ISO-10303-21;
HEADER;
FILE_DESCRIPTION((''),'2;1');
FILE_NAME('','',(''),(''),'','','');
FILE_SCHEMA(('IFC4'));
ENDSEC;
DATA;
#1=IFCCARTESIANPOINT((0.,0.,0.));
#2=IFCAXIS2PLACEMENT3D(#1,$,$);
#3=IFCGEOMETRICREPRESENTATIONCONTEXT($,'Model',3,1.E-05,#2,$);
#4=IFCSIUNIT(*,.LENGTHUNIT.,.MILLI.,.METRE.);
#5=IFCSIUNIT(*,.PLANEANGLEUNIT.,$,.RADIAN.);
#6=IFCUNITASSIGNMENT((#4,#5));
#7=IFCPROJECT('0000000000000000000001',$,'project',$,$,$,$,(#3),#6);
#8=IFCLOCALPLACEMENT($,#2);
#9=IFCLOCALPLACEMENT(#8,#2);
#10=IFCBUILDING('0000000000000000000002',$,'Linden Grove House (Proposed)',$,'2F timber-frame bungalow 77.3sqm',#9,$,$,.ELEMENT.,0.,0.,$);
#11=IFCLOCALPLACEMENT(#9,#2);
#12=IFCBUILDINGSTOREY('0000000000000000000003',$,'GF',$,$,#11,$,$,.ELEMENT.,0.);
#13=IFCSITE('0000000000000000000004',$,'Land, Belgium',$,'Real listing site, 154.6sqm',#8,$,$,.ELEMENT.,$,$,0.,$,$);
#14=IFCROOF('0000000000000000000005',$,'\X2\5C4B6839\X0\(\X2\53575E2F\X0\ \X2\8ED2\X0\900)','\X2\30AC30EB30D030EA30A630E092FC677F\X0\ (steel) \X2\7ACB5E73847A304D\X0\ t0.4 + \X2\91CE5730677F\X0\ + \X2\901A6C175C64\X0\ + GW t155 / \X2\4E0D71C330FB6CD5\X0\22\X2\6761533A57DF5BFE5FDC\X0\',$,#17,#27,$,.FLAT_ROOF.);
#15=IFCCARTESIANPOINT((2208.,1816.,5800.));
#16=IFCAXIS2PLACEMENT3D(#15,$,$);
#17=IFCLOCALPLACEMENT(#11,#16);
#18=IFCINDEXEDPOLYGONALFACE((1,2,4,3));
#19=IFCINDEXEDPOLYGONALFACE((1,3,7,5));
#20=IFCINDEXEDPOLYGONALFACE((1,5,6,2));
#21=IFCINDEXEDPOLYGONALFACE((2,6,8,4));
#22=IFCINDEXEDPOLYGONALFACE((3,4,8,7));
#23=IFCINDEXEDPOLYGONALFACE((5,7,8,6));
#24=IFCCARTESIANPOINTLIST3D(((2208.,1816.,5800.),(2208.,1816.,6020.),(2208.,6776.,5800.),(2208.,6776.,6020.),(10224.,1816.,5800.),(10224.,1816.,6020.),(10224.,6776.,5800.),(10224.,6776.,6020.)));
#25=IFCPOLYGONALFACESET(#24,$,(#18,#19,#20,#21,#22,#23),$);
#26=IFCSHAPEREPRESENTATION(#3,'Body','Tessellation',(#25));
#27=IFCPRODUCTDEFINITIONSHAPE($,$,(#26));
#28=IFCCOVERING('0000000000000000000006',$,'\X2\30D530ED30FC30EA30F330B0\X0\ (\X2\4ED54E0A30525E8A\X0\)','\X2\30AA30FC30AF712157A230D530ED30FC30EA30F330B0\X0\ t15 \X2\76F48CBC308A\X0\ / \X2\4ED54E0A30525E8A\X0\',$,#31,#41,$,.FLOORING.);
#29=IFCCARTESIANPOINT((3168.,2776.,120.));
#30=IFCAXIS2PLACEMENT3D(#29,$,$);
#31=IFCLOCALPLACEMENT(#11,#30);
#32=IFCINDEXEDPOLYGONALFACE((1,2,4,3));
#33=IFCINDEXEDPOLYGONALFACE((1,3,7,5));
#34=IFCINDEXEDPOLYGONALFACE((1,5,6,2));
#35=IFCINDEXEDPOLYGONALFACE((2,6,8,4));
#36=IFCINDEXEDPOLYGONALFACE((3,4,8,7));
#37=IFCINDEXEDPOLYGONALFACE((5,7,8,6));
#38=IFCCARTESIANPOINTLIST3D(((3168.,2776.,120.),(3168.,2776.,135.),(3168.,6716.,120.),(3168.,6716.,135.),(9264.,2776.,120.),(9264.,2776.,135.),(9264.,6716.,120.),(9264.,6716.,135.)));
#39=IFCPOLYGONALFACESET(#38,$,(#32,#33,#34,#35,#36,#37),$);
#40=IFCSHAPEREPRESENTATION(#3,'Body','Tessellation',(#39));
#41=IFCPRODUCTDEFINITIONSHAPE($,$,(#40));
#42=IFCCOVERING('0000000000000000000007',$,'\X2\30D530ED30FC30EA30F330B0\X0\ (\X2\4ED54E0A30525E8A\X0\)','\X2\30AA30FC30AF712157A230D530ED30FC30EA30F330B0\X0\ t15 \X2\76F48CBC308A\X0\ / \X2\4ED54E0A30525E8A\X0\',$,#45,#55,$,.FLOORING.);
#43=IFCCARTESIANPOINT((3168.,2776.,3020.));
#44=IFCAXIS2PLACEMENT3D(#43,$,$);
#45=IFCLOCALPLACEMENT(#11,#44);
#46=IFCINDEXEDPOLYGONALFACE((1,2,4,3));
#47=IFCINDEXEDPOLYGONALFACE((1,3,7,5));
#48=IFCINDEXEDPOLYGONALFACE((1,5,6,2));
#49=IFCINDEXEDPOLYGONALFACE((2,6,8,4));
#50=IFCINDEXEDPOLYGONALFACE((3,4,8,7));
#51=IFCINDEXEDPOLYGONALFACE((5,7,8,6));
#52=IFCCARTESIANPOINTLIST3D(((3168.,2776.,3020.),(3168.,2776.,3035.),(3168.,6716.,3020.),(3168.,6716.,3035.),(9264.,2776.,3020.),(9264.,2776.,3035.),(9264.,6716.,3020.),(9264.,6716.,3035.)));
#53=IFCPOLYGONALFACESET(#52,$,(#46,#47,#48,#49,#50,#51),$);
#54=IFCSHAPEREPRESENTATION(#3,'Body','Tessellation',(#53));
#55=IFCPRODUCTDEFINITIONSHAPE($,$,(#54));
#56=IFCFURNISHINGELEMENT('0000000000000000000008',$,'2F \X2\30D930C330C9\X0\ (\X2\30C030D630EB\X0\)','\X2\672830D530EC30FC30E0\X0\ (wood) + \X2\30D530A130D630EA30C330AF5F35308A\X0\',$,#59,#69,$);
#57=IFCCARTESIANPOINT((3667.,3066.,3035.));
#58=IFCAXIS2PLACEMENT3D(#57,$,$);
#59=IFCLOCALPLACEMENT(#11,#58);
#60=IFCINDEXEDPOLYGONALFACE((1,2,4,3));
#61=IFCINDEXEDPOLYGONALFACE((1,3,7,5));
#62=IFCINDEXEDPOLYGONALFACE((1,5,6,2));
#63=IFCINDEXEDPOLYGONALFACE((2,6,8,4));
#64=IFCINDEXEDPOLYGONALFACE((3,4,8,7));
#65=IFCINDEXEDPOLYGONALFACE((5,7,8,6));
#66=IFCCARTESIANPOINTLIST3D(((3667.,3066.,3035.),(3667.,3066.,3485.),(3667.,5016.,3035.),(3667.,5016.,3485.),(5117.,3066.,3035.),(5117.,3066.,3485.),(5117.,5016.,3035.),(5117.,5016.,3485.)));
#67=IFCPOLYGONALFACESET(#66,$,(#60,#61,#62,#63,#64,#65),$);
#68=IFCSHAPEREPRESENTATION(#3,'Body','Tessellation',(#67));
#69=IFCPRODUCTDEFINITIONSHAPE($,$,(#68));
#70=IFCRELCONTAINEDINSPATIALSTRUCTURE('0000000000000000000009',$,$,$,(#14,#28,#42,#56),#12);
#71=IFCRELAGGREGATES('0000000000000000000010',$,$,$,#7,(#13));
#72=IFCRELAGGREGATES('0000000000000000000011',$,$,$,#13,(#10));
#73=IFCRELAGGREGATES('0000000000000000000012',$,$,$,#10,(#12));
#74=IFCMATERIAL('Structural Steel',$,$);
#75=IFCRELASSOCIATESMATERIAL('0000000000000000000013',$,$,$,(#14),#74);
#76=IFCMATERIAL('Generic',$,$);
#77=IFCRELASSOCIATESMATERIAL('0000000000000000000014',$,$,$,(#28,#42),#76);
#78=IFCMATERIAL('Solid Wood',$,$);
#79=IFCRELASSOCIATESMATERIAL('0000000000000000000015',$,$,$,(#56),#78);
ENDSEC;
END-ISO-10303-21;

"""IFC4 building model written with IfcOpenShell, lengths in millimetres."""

from ifc_helpers import new_model, si_unit, frame, frame_2d, origin, place, context, project, spatial, rectangle, extrude, material, element, save


model = new_model("IFC4")

# Units and contexts
model_context = context("Model", 3, precision=1e-05, world=origin())
ifc_project = project(units=[si_unit("LENGTHUNIT", "METRE", prefix="MILLI"), si_unit("PLANEANGLEUNIT", "RADIAN")], contexts=[model_context])

# Site, building, storey
site_placement = place(None, origin())
site = spatial("IfcSite", under=ifc_project, at=site_placement, Name="Land, Belgium", ObjectType="Real listing site, 154.6sqm", CompositionType="ELEMENT", RefElevation=0.0)
building_placement = place(site_placement, origin())
building = spatial("IfcBuilding", under=site, at=building_placement, Name="Linden Grove House (Proposed)", ObjectType="2F timber-frame bungalow 77.3sqm", CompositionType="ELEMENT", ElevationOfRefHeight=0.0, ElevationOfTerrain=0.0)
storey_placement = place(building_placement, origin())
storey = spatial("IfcBuildingStorey", under=building, at=storey_placement, Name="GF", CompositionType="ELEMENT", Elevation=0.0)

# Shared definitions
ifc_material_1 = material(Name="Solid Wood")

# Roof
ifc_material_2 = material(Name="Structural Steel")
for number, where, name in (
    (1, (2208.0, 1816.0, 5800.0), "屋根(南帯 軒900)"),
):
    element("IfcRoof", number, at=place(storey_placement, frame(where)), inside=storey, material=ifc_material_2, Name=name, Description="ガルバリウム鋼板 (steel) 立平葺き t0.4 + 野地板 + 通気層 + GW t155 / 不燃・法22条区域対応", PredefinedType="FLAT_ROOF", context=model_context, shape_type="SweptSolid", body=[
        extrude(rectangle(XDim=8016.0, YDim=4960.0, at=frame_2d((4008.0, 2480.0))), frame((2208.0, 1816.0, 5800.0)), (0.0, 0.0, 1.0), 220.0),
    ])

# Coverings
ifc_material_3 = material(Name="Generic")
covering_1_placement = place(storey_placement, frame((3168.0, 2776.0, 120.0)))
element("IfcCovering", 2, at=covering_1_placement, inside=storey, material=ifc_material_3, Name="フローリング (仕上げ床)", Description="オーク無垢フローリング t15 直貼り / 仕上げ床", PredefinedType="FLOORING", context=model_context, shape_type="SweptSolid", body=[
    extrude(rectangle(XDim=6096.0, YDim=3940.0, at=frame_2d((3048.0, 1970.0))), frame((3168.0, 2776.0, 120.0)), (0.0, 0.0, 1.0), 15.0),
])
covering_2_placement = place(storey_placement, frame((3168.0, 2776.0, 3020.0)))
element("IfcCovering", 3, at=covering_2_placement, inside=storey, material=ifc_material_3, Name="フローリング (仕上げ床)", Description="オーク無垢フローリング t15 直貼り / 仕上げ床", PredefinedType="FLOORING", context=model_context, shape_type="SweptSolid", body=[
    extrude(rectangle(XDim=6096.0, YDim=3940.0, at=frame_2d((3048.0, 1970.0))), frame((3168.0, 2776.0, 3020.0)), (0.0, 0.0, 1.0), 15.0),
])

# Furnishing element
furnishing_placement = place(storey_placement, frame((3667.0, 3066.0, 3035.0)))
element("IfcFurnishingElement", 4, at=furnishing_placement, inside=storey, material=ifc_material_1, Name="2F ベッド (ダブル)", Description="木フレーム (wood) + ファブリック張り", context=model_context, shape_type="SweptSolid", body=[
    extrude(rectangle(XDim=1450.0, YDim=1950.0, at=frame_2d((725.0, 975.0))), frame((3667.0, 3066.0, 3035.0)), (0.0, 0.0, 1.0), 450.0),
])

save(model, "model.ifc")
